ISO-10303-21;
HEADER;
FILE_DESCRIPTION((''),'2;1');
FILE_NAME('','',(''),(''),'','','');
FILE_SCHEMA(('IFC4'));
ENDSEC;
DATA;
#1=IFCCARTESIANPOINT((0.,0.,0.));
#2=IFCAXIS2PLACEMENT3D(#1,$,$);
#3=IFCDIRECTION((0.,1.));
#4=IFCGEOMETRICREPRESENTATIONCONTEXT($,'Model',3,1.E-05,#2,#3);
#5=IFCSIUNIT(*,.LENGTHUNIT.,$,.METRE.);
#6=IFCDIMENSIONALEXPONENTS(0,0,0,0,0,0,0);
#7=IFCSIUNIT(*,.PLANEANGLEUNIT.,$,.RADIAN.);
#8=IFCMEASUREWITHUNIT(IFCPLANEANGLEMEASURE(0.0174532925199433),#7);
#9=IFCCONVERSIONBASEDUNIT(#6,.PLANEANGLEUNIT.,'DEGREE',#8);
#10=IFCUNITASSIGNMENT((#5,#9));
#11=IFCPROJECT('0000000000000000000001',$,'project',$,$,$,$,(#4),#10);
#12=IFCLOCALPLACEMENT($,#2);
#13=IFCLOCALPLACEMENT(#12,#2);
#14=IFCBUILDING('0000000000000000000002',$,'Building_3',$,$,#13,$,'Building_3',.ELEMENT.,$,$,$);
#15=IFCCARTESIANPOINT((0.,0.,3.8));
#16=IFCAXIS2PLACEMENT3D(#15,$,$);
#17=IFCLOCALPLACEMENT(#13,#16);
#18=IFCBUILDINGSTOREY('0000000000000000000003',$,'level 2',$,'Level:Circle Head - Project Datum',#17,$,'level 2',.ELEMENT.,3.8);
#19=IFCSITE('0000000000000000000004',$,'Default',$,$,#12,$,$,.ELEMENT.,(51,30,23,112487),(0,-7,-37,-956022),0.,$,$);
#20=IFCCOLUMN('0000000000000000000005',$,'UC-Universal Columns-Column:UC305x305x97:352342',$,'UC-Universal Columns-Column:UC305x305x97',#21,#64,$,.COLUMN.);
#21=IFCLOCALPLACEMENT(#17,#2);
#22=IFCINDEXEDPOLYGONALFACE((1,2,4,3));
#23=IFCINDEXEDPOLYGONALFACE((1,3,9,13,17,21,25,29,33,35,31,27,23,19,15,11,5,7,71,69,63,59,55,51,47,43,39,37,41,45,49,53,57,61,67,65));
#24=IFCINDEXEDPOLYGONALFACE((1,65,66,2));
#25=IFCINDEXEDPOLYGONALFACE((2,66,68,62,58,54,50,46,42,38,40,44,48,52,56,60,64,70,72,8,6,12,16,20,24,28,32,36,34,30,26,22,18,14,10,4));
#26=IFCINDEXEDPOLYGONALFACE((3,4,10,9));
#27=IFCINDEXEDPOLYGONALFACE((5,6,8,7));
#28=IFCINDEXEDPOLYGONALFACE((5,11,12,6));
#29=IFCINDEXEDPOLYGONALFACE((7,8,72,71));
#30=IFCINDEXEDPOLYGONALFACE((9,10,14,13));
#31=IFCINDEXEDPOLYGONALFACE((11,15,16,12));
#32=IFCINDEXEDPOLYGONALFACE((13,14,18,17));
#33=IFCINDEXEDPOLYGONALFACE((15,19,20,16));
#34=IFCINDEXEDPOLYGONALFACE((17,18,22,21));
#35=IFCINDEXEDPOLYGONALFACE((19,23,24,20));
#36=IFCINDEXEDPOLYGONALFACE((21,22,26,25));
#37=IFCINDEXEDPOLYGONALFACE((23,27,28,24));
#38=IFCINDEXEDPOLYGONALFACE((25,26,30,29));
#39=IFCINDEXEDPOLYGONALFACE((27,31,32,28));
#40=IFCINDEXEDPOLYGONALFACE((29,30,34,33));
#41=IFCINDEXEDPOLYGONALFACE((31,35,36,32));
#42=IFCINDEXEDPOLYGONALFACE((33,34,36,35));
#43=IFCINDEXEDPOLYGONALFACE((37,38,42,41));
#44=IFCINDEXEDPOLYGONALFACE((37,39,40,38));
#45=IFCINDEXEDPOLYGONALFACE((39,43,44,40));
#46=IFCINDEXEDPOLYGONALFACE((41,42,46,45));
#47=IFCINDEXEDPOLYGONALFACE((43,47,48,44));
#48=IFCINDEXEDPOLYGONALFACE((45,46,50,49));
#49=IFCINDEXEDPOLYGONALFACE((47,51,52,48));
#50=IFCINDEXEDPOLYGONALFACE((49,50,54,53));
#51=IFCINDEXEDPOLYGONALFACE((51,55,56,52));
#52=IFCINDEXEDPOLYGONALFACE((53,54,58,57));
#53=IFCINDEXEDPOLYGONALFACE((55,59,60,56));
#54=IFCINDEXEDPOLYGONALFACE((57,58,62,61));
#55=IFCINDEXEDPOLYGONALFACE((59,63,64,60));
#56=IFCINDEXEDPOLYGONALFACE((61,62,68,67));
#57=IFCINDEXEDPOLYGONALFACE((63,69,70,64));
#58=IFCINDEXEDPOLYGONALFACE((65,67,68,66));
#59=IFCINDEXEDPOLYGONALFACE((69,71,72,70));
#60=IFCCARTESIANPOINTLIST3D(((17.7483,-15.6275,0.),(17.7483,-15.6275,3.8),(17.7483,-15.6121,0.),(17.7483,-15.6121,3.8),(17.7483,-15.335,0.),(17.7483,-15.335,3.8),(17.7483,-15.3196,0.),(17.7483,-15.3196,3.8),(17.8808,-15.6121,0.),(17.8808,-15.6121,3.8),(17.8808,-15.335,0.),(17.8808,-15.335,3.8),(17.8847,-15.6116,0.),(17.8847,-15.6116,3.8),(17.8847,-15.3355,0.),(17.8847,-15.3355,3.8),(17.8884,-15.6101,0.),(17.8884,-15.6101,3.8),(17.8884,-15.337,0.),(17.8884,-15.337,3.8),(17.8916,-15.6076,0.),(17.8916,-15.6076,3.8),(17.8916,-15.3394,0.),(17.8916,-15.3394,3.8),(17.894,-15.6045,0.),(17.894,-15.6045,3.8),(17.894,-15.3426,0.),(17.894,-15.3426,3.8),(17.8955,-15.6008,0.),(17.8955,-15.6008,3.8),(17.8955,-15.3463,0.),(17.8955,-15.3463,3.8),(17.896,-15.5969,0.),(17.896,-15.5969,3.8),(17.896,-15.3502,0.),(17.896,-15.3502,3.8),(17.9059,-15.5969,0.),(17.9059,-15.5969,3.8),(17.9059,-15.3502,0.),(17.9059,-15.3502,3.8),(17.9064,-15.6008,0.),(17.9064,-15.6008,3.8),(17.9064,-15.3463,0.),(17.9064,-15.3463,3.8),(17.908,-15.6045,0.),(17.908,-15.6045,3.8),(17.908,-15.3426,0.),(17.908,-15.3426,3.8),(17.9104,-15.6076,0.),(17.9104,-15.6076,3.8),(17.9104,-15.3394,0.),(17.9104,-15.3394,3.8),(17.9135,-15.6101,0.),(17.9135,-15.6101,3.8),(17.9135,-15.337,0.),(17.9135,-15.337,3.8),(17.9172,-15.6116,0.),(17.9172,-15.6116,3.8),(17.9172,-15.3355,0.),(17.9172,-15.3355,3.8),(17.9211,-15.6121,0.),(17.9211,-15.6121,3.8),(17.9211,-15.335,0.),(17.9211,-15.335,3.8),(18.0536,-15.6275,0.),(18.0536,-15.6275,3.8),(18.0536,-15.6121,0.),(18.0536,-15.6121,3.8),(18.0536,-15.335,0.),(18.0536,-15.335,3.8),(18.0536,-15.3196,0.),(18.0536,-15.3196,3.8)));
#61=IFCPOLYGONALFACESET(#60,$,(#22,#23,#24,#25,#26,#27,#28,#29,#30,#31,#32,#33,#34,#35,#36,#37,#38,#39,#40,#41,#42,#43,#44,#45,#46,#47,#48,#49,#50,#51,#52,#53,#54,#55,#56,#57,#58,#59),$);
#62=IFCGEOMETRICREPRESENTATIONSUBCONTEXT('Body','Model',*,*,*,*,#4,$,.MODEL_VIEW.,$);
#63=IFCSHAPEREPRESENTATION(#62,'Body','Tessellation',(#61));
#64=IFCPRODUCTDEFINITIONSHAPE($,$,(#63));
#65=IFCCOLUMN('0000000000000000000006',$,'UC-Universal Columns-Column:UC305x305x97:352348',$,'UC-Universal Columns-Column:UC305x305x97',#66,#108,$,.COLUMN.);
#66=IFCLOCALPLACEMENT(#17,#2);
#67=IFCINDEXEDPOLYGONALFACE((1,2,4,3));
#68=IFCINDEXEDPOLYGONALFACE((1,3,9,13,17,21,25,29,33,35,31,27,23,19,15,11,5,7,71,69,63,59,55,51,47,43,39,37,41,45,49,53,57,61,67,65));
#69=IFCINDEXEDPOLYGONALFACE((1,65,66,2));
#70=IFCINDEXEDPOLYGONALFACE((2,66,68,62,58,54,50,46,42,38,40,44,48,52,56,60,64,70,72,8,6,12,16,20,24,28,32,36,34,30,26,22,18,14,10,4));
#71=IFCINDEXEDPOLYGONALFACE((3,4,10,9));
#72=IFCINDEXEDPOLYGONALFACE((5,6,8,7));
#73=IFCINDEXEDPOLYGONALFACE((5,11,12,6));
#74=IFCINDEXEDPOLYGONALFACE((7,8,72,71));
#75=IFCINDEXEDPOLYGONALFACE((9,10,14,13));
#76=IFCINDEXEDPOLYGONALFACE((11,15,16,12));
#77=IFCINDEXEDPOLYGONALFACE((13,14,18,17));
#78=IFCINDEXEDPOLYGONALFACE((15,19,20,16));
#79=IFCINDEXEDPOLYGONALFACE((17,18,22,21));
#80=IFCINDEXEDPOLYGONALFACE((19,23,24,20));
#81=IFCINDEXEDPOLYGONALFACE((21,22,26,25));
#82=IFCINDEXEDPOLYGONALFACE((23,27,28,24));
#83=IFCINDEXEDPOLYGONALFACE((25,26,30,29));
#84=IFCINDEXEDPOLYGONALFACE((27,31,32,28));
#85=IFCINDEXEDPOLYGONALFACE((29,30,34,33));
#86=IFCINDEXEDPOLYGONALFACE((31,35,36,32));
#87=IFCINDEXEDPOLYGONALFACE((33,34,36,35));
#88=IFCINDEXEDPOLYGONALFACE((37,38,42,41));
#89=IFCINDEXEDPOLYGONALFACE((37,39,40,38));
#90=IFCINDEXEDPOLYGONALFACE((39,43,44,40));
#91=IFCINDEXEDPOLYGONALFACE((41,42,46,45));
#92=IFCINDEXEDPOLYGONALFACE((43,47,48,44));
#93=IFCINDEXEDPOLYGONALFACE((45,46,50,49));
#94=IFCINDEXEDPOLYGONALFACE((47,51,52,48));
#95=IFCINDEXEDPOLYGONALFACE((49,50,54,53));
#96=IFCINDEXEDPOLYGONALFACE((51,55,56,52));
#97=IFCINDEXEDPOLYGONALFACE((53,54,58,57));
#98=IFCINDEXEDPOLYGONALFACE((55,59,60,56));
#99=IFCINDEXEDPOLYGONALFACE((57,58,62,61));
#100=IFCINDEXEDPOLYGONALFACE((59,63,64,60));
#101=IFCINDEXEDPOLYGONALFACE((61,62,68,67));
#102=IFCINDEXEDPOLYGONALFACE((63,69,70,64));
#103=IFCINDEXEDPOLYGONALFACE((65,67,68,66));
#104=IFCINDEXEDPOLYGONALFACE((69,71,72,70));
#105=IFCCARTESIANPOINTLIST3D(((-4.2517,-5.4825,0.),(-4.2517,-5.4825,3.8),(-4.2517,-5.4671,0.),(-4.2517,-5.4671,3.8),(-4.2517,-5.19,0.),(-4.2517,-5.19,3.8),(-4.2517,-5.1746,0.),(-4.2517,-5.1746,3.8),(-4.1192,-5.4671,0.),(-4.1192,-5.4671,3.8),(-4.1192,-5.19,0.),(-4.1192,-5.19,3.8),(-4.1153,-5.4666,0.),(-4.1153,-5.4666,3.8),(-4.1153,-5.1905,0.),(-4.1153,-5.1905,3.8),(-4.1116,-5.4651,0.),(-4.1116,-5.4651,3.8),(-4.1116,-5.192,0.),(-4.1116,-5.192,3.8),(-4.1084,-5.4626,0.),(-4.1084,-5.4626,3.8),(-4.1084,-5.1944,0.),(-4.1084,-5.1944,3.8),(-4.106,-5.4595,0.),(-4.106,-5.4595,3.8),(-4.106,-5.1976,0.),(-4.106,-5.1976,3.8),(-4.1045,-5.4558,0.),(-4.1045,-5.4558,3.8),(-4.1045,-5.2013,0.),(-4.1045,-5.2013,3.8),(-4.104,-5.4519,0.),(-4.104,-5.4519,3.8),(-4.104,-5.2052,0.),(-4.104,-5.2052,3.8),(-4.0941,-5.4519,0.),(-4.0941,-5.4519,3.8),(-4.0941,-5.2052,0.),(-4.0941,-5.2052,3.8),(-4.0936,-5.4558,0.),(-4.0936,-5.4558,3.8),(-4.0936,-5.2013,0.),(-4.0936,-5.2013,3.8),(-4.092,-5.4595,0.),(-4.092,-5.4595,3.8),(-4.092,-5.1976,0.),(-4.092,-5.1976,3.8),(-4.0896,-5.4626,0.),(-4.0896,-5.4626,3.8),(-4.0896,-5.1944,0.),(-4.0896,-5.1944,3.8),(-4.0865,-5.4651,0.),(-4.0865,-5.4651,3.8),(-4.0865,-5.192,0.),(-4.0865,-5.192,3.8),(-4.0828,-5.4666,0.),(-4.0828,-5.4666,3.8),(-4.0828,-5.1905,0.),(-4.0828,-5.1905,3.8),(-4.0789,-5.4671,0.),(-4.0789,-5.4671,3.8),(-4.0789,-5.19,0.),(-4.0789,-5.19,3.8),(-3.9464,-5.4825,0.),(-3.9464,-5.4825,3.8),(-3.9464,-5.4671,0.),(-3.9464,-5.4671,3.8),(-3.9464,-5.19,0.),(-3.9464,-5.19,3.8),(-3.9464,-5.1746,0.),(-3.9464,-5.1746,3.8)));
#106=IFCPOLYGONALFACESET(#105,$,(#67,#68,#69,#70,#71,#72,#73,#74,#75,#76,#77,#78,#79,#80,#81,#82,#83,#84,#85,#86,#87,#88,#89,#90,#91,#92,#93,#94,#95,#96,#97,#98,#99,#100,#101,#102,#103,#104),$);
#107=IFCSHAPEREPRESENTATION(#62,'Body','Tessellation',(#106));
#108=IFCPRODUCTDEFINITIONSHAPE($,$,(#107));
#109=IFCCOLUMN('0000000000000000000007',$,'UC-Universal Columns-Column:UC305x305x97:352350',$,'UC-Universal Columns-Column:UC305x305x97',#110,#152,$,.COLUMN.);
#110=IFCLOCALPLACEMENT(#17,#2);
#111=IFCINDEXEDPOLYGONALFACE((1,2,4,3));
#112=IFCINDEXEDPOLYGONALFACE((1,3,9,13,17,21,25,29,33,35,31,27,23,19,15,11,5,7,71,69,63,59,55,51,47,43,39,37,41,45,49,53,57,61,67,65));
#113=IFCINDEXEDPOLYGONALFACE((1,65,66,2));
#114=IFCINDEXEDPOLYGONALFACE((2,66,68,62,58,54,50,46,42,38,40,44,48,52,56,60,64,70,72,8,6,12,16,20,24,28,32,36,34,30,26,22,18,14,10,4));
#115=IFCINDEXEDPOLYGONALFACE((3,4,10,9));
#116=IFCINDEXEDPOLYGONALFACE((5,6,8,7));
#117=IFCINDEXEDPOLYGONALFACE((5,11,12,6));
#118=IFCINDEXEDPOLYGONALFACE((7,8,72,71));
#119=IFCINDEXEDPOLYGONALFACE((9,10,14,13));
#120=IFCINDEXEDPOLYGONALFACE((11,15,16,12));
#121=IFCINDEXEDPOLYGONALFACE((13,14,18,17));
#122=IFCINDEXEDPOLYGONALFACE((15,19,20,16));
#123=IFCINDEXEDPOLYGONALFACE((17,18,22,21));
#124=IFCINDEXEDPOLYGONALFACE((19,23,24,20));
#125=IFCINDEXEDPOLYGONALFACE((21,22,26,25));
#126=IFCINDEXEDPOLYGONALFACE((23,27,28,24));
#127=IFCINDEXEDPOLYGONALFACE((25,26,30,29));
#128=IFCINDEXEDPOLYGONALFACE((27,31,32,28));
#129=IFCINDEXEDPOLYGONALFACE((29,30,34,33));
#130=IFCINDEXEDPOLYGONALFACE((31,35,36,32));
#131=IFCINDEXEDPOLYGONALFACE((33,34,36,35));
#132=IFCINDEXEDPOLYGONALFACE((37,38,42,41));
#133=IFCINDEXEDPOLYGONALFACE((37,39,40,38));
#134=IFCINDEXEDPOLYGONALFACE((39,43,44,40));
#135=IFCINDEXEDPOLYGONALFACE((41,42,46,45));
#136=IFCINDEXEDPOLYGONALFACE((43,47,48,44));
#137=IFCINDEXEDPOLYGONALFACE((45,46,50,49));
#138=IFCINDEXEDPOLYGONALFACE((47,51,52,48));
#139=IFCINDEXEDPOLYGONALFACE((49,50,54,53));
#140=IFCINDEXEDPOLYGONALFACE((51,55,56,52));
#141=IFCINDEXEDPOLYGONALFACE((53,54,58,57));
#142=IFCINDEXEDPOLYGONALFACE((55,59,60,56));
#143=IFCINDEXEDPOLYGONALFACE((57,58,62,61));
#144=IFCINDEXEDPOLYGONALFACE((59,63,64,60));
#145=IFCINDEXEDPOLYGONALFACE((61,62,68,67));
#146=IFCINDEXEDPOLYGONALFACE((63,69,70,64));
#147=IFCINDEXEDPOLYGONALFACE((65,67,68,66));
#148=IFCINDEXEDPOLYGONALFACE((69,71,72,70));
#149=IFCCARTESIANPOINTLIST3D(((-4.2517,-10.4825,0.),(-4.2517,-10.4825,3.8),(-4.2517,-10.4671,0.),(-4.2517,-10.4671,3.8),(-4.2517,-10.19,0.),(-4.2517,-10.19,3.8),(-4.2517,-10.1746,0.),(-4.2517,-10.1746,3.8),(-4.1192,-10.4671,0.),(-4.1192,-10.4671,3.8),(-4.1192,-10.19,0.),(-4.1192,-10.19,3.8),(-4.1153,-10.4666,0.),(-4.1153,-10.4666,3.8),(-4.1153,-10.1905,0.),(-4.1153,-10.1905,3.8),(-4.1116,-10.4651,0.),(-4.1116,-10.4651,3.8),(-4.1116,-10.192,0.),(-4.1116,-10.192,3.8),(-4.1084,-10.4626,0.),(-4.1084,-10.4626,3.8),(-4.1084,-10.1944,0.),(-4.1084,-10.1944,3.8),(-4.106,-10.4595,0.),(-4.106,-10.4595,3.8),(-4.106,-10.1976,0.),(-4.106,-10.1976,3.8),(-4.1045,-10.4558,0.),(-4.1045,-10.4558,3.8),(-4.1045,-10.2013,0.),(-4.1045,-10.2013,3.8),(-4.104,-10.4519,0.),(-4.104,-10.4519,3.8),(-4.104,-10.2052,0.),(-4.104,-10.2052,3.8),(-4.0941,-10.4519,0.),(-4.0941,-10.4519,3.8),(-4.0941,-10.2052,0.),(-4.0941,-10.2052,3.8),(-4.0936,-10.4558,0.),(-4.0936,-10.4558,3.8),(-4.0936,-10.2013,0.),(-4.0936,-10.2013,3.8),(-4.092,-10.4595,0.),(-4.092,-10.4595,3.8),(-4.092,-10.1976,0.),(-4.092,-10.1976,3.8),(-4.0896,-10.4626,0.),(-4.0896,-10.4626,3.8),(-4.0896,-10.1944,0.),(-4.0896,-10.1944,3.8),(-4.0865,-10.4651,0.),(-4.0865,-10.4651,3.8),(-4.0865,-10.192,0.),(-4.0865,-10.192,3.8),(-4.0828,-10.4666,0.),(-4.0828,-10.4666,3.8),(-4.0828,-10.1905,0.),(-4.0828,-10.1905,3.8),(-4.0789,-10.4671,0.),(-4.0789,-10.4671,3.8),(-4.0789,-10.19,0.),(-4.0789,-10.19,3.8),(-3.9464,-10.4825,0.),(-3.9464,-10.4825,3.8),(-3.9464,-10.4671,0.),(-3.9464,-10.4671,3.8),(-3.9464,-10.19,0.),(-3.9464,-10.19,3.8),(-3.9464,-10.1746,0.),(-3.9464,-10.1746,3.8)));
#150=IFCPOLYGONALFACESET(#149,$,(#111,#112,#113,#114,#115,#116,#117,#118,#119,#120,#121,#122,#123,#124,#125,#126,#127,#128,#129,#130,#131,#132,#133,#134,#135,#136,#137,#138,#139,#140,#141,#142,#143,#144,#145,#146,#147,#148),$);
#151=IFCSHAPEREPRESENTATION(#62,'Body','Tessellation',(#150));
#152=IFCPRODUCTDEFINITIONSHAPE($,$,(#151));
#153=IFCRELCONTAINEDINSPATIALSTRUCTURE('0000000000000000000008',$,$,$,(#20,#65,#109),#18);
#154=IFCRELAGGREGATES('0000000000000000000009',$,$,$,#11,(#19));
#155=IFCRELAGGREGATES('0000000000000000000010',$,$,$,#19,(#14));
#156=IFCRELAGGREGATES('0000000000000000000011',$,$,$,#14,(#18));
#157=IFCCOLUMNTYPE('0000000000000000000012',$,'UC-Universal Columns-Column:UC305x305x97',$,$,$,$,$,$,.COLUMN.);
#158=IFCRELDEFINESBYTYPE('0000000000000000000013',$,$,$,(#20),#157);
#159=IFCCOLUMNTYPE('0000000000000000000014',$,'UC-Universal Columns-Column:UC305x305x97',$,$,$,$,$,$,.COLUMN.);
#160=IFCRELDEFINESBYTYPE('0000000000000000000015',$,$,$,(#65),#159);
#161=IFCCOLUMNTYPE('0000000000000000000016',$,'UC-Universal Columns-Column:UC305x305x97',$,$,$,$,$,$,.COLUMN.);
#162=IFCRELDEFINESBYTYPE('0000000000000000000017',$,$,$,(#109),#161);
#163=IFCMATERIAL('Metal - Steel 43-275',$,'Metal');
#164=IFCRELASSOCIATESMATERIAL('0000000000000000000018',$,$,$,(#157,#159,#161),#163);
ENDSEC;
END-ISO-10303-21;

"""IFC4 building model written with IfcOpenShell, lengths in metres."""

from ifc_helpers import new_model, entity, si_unit, converted_unit, direction, frame, frame_2d, origin, origin_2d_with_axis, place, context, subcontext, project, spatial, i_section, extrude, source, transform, mapped, material, material_profile, profile_set, type_object, type_shapes, element, save


model = new_model("IFC4")

# Units and contexts
model_context = context("Model", 3, precision=1e-05, world=origin(), true_north=direction((0.0, 1.0)))
body_context = subcontext(model_context, "Body", "Model", "MODEL_VIEW")
ifc_project = project(units=[si_unit("LENGTHUNIT", "METRE"), converted_unit("PLANEANGLEUNIT", "DEGREE", entity("IfcPlaneAngleMeasure", 0.0174532925199433), si_unit("PLANEANGLEUNIT", "RADIAN"), dimensions=[0, 0, 0, 0, 0, 0, 0])], contexts=[model_context])

# Site, building, storey
site_placement = place(None, origin())
site = spatial("IfcSite", under=ifc_project, at=site_placement, Name="Default", CompositionType="ELEMENT", RefLatitude=(51, 30, 23, 112487), RefLongitude=(0, -7, -37, -956022), RefElevation=0.0)
building_placement = place(site_placement, origin())
building = spatial("IfcBuilding", under=site, at=building_placement, Name="Building_3", LongName="Building_3", CompositionType="ELEMENT")
storey_placement = place(building_placement, frame((0.0, 0.0, 3.8)))
storey = spatial("IfcBuildingStorey", under=building, at=storey_placement, Name="level 2", ObjectType="Level:Circle Head - Project Datum", LongName="level 2", CompositionType="ELEMENT", Elevation=3.8)

# Columns
ifc_material_1 = material(Name="Metal - Steel 43-275", Category="Metal")
ifc_material_profile_1 = material_profile(ifc_material_1, i_section(OverallWidth=0.3053, OverallDepth=0.3079, WebThickness=0.0099, FlangeThickness=0.0154, FilletRadius=0.0152, at=frame_2d((0.0, 0.0), x_axis=(1.0, 0.0))), Name="UC305x305x97")
ifc_profile_set_1 = profile_set([ifc_material_profile_1], Name="UC305x305x97")
column_type_1 = type_object("IfcColumnType", Name="UC-Universal Columns-Column:UC305x305x97", PredefinedType="COLUMN", material=ifc_profile_set_1)
shared_shape_1 = source(origin(), body_context, "Body", "SweptSolid", [
    extrude(i_section(OverallWidth=0.3053, OverallDepth=0.3079, WebThickness=0.0099, FlangeThickness=0.0154, FilletRadius=0.0152, at=frame_2d((0.0, 0.0), x_axis=(1.0, 0.0))), frame((17.901, -15.4735, 3.8), z_axis=(0.0, 0.0, 1.0), x_axis=(-1.0, 0.0, 0.0)), (0.0, 0.0, 1.0), 3.8),
])
type_shapes(column_type_1, [shared_shape_1])
column_1_placement = place(storey_placement, frame((0.0, 0.0, -3.8)))
element("IfcColumn", 1, at=column_1_placement, inside=storey, type_object=column_type_1, Name="UC-Universal Columns-Column:UC305x305x97:352342", ObjectType="UC-Universal Columns-Column:UC305x305x97", PredefinedType="COLUMN", context=body_context, shape_type="MappedRepresentation", body=[
    mapped(shared_shape_1, transform((0.0, 0.0, 0.0), scale=1.0)),
])
column_type_2 = type_object("IfcColumnType", Name="UC-Universal Columns-Column:UC305x305x97", PredefinedType="COLUMN", material=ifc_profile_set_1)
shared_shape_2 = source(origin(), body_context, "Body", "SweptSolid", [
    extrude(i_section(OverallWidth=0.3053, OverallDepth=0.3079, WebThickness=0.0099, FlangeThickness=0.0154, FilletRadius=0.0152, at=frame_2d((0.0, 0.0), x_axis=(1.0, 0.0))), frame((-4.099, -5.3285, 3.8), z_axis=(0.0, 0.0, 1.0), x_axis=(-1.0, 0.0, 0.0)), (0.0, 0.0, 1.0), 3.8),
])
type_shapes(column_type_2, [shared_shape_2])
column_2_placement = place(storey_placement, frame((0.0, 0.0, -3.8)))
element("IfcColumn", 2, at=column_2_placement, inside=storey, type_object=column_type_2, Name="UC-Universal Columns-Column:UC305x305x97:352348", ObjectType="UC-Universal Columns-Column:UC305x305x97", PredefinedType="COLUMN", context=body_context, shape_type="MappedRepresentation", body=[
    mapped(shared_shape_2, transform((0.0, 0.0, 0.0), scale=1.0)),
])
column_type_3 = type_object("IfcColumnType", Name="UC-Universal Columns-Column:UC305x305x97", PredefinedType="COLUMN", material=ifc_profile_set_1)
shared_shape_3 = source(origin(), body_context, "Body", "SweptSolid", [
    extrude(i_section(OverallWidth=0.3053, OverallDepth=0.3079, WebThickness=0.0099, FlangeThickness=0.0154, FilletRadius=0.0152, at=origin_2d_with_axis()), frame((-4.099, -10.3285, 3.8), z_axis=(0.0, 0.0, 1.0), x_axis=(-1.0, 0.0, 0.0)), (0.0, 0.0, 1.0), 3.8),
])
type_shapes(column_type_3, [shared_shape_3])
column_3_placement = place(storey_placement, frame((0.0, 0.0, -3.8)))
element("IfcColumn", 3, at=column_3_placement, inside=storey, type_object=column_type_3, Name="UC-Universal Columns-Column:UC305x305x97:352350", ObjectType="UC-Universal Columns-Column:UC305x305x97", PredefinedType="COLUMN", context=body_context, shape_type="MappedRepresentation", body=[
    mapped(shared_shape_3, transform((0.0, 0.0, 0.0), scale=1.0)),
])

save(model, "model.ifc")
